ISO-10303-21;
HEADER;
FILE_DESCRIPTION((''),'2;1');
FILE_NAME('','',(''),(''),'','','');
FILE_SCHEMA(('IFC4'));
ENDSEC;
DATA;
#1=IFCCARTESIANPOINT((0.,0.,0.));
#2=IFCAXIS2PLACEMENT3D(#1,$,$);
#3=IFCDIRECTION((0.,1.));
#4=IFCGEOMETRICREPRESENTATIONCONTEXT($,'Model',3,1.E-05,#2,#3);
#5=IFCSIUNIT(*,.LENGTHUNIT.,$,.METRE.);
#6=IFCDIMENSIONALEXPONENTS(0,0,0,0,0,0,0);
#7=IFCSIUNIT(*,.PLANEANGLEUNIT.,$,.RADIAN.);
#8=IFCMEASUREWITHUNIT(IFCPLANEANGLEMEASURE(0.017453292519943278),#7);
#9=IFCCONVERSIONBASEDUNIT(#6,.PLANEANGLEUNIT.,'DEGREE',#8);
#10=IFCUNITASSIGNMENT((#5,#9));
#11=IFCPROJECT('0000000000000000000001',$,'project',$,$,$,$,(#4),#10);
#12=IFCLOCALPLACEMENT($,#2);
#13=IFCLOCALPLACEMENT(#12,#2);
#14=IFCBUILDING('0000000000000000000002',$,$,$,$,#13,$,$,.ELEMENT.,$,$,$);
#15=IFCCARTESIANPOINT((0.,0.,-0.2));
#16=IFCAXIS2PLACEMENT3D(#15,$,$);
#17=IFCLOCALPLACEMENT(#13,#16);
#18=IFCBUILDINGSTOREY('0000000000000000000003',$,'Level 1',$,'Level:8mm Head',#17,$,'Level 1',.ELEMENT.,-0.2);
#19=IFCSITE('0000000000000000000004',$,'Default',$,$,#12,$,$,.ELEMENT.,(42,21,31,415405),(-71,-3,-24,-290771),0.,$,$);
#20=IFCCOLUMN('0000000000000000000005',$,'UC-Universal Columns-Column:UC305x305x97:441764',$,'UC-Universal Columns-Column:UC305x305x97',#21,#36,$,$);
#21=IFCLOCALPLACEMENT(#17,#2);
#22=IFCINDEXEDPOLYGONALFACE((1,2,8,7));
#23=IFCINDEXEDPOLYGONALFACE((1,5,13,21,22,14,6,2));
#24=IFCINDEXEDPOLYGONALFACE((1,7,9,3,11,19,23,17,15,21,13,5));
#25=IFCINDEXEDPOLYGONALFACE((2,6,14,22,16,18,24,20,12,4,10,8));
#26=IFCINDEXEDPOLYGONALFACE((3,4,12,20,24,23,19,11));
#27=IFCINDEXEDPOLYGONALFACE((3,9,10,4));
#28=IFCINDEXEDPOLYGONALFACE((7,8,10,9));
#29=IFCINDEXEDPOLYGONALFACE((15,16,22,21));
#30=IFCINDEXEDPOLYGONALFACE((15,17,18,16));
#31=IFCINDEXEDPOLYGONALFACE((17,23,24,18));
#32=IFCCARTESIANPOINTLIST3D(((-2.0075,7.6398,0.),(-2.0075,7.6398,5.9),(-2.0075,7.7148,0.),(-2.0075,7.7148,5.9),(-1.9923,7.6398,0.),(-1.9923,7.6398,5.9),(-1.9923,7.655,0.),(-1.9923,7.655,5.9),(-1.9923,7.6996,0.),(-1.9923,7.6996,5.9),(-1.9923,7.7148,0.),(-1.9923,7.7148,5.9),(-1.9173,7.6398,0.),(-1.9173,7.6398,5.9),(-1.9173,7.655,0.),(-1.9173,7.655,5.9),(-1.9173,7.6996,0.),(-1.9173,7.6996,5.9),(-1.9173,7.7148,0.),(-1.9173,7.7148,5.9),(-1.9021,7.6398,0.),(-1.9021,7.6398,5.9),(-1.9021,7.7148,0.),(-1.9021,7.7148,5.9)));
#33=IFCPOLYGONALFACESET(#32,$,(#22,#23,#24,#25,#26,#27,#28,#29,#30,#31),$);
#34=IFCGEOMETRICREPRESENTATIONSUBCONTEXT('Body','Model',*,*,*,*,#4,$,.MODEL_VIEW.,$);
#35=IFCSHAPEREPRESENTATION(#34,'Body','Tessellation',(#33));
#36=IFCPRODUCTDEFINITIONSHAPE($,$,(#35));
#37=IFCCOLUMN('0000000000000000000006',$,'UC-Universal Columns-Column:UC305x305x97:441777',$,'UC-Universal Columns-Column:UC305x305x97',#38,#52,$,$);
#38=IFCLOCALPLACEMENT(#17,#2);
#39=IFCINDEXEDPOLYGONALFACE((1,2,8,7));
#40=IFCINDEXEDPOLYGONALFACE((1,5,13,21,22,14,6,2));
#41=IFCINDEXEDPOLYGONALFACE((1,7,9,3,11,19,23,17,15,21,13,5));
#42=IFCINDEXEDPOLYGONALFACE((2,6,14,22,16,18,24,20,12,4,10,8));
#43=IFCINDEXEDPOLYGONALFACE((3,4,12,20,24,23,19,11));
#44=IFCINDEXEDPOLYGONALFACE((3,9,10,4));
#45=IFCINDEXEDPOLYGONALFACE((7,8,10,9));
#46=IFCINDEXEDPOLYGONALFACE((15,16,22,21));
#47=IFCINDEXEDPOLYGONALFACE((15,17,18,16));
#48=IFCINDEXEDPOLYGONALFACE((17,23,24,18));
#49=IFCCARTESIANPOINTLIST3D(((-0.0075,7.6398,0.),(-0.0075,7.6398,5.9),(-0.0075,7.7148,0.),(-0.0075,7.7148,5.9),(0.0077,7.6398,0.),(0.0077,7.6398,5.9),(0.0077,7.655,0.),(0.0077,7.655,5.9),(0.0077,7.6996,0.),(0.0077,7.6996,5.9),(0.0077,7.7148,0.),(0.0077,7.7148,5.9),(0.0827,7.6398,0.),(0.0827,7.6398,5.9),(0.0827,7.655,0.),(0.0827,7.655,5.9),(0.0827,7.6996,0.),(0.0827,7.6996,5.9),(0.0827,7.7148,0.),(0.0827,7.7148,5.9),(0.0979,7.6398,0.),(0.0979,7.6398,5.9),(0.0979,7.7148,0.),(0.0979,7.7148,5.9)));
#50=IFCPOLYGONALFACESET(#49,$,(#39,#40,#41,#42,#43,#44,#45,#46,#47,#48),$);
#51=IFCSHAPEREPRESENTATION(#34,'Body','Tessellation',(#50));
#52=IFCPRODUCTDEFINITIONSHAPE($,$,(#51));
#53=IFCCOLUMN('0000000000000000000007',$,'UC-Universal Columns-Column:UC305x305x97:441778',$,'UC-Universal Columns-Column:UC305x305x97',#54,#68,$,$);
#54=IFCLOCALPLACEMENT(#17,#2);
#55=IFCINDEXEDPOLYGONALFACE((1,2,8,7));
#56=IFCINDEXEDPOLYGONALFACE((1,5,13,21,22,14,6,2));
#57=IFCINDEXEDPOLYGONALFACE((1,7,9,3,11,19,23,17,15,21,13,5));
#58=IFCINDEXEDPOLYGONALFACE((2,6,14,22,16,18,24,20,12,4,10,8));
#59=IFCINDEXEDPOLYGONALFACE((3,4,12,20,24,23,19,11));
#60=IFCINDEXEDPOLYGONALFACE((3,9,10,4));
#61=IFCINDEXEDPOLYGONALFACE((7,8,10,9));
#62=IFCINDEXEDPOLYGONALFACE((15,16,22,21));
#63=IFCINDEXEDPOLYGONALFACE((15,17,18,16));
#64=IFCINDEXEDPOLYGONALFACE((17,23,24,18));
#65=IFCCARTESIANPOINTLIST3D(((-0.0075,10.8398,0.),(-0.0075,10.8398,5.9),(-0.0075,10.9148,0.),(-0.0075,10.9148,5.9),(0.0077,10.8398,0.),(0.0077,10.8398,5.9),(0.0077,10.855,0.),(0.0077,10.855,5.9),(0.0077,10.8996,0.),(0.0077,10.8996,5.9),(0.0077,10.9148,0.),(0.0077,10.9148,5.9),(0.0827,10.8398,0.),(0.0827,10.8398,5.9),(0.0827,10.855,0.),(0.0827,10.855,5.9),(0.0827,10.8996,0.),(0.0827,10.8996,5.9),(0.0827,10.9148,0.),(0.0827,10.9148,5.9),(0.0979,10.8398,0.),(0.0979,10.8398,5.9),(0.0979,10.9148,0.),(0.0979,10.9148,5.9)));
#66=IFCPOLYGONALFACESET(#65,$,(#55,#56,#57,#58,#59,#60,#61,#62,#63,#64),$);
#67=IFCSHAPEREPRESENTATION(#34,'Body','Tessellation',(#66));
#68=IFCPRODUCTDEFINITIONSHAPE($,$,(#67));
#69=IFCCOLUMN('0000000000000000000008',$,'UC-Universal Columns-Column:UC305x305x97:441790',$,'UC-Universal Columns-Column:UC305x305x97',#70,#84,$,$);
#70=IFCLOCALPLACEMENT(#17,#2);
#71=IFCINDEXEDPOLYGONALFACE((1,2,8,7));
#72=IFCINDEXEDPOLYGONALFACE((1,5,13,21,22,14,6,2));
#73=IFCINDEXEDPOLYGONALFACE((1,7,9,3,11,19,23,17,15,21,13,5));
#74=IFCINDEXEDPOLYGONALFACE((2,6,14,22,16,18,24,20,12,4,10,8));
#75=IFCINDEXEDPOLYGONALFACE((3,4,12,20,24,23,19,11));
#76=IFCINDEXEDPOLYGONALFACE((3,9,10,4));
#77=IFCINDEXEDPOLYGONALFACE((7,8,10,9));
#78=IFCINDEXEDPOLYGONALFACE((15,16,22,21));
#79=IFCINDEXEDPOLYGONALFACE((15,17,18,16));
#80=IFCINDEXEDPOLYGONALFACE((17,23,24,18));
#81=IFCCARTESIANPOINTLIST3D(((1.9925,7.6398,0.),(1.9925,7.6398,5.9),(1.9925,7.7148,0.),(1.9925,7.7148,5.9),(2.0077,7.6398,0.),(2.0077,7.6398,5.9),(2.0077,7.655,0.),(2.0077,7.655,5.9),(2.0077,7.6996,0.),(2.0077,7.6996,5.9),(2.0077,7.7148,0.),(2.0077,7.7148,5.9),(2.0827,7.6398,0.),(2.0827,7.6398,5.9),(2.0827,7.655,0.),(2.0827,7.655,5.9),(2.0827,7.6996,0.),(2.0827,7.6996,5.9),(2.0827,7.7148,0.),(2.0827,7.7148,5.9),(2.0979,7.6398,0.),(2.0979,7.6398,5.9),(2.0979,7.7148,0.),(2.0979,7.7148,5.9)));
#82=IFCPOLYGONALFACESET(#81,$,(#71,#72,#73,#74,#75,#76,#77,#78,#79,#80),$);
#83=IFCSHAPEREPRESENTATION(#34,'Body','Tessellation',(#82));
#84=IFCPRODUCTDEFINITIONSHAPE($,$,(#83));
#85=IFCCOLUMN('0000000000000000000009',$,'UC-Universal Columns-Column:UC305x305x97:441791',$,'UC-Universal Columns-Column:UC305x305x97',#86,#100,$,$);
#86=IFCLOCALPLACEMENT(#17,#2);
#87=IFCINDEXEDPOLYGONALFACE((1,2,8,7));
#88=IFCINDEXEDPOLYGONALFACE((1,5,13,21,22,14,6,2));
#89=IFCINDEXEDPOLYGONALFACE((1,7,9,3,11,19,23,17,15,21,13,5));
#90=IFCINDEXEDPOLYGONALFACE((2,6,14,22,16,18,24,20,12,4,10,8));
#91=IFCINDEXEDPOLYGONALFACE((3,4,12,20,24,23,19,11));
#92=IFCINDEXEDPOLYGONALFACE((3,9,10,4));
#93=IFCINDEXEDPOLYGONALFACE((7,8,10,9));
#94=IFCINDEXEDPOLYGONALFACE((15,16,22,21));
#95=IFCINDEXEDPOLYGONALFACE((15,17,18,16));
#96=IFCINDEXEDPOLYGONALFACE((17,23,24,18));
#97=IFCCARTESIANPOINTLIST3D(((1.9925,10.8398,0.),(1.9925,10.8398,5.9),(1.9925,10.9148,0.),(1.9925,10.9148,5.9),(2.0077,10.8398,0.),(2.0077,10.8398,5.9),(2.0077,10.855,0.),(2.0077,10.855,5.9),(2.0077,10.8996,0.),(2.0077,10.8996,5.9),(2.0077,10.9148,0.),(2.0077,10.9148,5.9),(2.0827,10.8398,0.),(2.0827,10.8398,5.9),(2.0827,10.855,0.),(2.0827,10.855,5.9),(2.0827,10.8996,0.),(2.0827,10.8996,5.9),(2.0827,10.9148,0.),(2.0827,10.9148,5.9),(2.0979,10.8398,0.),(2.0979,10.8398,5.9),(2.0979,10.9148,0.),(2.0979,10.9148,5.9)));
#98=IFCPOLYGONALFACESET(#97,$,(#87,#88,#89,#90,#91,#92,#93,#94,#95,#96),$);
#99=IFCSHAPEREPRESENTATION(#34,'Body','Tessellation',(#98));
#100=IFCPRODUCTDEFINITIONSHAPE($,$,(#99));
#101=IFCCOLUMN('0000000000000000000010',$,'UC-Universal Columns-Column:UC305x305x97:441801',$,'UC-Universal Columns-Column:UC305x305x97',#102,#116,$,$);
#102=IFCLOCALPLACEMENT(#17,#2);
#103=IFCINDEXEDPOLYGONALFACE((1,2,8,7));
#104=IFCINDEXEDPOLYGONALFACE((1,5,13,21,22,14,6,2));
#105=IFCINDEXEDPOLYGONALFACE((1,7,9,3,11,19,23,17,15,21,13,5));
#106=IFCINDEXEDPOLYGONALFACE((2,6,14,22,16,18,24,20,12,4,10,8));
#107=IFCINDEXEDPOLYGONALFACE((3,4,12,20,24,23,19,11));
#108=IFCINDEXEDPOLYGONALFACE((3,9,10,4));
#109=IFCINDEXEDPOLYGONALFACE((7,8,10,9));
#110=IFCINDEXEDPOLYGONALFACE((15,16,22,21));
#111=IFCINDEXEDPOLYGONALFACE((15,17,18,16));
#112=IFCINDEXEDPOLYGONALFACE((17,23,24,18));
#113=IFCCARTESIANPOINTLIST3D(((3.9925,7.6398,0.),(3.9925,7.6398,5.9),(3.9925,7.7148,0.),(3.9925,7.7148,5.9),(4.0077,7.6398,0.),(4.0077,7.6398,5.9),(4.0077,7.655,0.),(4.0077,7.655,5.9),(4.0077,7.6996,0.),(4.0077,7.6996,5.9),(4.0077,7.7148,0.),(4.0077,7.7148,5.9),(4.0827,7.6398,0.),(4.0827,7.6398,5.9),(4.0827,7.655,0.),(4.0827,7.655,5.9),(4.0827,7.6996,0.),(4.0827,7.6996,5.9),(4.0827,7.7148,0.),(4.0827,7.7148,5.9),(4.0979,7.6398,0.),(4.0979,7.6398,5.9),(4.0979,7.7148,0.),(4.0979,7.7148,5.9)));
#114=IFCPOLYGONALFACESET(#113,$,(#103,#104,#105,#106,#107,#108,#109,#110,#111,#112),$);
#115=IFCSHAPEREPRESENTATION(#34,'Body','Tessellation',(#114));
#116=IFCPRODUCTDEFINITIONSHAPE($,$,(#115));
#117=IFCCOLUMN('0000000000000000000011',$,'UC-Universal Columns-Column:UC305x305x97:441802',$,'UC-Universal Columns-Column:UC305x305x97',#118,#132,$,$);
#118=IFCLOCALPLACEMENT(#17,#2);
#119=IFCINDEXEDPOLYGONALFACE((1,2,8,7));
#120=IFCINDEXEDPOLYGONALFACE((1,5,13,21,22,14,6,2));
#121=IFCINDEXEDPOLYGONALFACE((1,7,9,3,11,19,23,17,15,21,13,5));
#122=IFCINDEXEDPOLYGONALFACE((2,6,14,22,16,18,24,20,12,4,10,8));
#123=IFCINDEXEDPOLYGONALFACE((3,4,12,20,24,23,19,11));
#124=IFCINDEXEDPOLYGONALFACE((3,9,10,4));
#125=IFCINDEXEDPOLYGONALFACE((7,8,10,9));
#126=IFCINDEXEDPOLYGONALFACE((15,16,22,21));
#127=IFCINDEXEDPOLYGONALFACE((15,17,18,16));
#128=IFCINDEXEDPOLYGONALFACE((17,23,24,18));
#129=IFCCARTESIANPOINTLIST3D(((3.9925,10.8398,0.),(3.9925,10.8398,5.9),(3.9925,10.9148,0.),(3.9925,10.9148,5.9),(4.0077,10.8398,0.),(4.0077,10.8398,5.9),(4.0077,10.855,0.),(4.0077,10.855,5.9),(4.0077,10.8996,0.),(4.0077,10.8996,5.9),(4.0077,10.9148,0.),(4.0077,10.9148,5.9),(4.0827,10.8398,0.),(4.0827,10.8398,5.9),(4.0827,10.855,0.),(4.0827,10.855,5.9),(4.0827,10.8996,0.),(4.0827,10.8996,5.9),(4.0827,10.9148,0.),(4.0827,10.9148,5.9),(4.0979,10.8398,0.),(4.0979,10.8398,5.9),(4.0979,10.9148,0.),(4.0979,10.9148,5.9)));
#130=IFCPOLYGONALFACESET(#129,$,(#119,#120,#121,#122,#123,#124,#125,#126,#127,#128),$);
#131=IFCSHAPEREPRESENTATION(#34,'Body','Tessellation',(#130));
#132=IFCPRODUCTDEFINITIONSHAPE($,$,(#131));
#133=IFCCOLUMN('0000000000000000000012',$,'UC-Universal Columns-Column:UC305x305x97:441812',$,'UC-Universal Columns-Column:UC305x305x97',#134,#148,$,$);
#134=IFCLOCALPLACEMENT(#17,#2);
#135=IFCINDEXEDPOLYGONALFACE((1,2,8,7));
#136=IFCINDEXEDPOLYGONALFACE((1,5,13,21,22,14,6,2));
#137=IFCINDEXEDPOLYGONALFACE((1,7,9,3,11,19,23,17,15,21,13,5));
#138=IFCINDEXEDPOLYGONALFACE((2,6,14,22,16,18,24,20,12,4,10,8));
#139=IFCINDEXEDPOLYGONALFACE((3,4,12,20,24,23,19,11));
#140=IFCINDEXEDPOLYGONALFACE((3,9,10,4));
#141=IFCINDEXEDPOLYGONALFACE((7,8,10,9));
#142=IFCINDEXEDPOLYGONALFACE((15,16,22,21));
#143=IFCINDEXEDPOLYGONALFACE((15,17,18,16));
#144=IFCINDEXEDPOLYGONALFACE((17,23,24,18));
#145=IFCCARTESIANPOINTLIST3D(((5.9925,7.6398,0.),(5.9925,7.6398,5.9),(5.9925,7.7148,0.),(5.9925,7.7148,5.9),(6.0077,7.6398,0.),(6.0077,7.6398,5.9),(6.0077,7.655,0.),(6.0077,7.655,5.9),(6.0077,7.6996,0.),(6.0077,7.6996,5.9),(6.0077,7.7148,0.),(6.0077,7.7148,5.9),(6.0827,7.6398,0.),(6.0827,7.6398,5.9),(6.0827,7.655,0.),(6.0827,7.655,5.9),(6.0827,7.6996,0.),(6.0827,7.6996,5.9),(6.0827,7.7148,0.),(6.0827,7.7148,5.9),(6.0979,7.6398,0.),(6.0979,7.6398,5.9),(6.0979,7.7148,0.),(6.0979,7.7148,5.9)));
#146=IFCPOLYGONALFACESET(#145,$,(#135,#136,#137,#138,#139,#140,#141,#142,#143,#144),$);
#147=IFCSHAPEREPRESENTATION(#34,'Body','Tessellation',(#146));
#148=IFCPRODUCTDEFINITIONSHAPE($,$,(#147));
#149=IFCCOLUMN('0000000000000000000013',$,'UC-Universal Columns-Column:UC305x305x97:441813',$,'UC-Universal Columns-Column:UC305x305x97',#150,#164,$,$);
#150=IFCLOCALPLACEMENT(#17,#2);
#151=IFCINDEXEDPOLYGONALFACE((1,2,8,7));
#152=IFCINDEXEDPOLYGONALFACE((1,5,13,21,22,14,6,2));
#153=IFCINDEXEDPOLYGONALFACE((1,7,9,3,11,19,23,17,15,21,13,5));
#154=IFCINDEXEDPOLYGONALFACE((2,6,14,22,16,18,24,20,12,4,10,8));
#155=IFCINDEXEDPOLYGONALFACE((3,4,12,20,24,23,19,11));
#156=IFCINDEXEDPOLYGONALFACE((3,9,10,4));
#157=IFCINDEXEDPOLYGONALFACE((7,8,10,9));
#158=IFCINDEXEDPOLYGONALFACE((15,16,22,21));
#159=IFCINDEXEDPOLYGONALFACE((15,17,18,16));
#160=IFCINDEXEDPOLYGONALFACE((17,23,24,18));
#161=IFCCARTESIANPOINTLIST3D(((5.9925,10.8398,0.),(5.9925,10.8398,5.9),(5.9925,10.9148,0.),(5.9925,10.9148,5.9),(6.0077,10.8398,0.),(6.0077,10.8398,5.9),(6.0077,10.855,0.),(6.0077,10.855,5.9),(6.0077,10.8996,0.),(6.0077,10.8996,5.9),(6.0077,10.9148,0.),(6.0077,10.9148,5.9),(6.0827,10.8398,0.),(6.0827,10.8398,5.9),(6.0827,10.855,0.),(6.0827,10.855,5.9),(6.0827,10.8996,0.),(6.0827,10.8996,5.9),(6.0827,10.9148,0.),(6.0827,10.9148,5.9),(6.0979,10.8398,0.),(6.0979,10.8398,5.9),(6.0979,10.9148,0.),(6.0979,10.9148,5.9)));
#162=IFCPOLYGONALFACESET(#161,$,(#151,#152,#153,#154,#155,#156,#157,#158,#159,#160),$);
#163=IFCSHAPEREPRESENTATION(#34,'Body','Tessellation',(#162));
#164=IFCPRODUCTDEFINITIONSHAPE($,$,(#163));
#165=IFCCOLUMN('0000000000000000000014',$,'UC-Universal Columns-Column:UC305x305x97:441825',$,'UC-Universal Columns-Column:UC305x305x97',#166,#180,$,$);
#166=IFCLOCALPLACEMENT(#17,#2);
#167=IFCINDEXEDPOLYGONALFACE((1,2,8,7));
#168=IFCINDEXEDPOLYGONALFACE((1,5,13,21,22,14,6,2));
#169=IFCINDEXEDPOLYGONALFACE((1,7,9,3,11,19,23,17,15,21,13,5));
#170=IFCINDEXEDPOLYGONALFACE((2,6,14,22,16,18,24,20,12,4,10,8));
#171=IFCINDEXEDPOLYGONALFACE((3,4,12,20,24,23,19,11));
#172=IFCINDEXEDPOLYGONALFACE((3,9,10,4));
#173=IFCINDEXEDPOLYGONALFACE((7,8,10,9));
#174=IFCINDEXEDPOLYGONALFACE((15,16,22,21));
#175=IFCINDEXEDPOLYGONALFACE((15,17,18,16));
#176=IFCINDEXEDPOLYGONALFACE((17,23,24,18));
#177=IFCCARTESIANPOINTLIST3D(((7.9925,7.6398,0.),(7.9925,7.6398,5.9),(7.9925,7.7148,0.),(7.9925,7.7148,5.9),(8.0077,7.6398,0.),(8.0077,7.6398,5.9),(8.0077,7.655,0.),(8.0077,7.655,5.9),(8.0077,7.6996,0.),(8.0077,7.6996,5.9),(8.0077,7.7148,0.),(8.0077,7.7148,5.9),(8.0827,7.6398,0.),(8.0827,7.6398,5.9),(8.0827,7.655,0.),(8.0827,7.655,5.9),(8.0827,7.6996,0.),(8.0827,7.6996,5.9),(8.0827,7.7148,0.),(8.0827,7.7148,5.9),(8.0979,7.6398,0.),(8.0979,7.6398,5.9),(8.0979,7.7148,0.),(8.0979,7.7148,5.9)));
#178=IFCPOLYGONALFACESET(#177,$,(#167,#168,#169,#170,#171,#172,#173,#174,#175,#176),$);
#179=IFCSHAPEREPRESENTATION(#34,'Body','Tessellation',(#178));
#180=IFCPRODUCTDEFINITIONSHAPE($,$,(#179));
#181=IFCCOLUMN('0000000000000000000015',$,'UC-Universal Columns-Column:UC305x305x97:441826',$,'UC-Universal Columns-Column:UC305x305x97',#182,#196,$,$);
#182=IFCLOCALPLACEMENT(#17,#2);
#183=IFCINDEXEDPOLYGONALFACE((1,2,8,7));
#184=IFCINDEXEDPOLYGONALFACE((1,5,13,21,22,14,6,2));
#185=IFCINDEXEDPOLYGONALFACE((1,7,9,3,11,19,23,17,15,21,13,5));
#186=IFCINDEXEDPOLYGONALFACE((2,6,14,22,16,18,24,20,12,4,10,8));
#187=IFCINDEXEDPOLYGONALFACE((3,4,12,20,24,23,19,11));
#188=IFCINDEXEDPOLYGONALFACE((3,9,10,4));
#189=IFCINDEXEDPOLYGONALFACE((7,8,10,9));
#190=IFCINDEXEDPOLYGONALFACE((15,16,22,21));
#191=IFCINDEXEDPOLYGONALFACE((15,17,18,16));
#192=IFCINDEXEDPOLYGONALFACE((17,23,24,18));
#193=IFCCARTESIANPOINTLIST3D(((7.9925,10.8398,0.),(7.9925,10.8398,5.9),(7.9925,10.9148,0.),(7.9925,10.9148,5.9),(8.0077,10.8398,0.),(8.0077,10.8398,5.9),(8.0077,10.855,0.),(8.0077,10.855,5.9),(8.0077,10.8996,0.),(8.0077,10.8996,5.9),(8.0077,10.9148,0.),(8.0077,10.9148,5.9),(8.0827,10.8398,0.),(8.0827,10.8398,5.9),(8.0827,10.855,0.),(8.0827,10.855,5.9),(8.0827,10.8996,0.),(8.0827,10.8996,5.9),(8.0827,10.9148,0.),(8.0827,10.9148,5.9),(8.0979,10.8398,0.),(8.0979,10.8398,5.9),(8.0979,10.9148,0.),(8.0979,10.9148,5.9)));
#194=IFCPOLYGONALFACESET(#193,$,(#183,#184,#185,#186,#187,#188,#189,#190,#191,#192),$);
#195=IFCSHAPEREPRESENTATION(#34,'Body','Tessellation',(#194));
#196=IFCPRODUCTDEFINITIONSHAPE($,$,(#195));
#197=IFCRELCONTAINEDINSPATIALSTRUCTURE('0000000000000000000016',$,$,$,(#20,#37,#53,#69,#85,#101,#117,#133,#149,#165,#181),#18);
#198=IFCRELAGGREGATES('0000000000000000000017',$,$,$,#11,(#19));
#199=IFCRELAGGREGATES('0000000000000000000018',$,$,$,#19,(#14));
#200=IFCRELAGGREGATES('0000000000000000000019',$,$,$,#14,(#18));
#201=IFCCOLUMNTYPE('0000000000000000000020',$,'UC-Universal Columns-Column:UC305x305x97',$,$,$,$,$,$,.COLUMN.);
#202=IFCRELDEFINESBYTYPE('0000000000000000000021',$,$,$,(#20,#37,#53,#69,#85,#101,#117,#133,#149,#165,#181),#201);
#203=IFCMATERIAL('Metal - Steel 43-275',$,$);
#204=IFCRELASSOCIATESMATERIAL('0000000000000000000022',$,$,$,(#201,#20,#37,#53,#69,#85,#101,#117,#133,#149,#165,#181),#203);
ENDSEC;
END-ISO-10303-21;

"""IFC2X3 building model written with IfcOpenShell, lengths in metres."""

from ifc_helpers import new_model, entity, si_unit, converted_unit, direction, frame, frame_2d, origin, place, context, subcontext, project, spatial, polyline, circle_curve, parameter, trimmed, segment, composite_curve, outline, extrude, source, transform, mapped, material, type_object, type_shapes, element, save


model = new_model("IFC2X3")

# Units and contexts
model_context = context("Model", 3, precision=1e-05, world=origin(), true_north=direction((0.0, 1.0)))
body_context = subcontext(model_context, "Body", "Model", "MODEL_VIEW")
ifc_project = project(units=[si_unit("LENGTHUNIT", "METRE"), converted_unit("PLANEANGLEUNIT", "DEGREE", entity("IfcPlaneAngleMeasure", 0.017453292519943278), si_unit("PLANEANGLEUNIT", "RADIAN"), dimensions=[0, 0, 0, 0, 0, 0, 0])], contexts=[model_context])

# Site, building, storey
site_placement = place(None, origin())
site = spatial("IfcSite", under=ifc_project, at=site_placement, Name="Default", CompositionType="ELEMENT", RefLatitude=(42, 21, 31, 415405), RefLongitude=(-71, -3, -24, -290771), RefElevation=0.0)
building_placement = place(site_placement, origin())
building = spatial("IfcBuilding", under=site, at=building_placement, CompositionType="ELEMENT")
storey_placement = place(building_placement, frame((0.0, 0.0, -0.2)))
storey = spatial("IfcBuildingStorey", under=building, at=storey_placement, Name="Level 1", ObjectType="Level:8mm Head", LongName="Level 1", CompositionType="ELEMENT", Elevation=-0.2)

# Columns
ifc_material_1 = material(Name="Metal - Steel 43-275")
column_type_1 = type_object("IfcColumnType", Name="UC-Universal Columns-Column:UC305x305x97", PredefinedType="COLUMN", material=ifc_material_1)
shared_shape_1 = source(origin(), body_context, "Body", "SweptSolid", [
    extrude(outline(composite_curve([segment(polyline([(-0.0375, -0.0375), (0.0375, -0.0375)]), True, "CONTINUOUS"), segment(polyline([(0.0375, -0.0375), (0.0527, -0.0375)]), True, "CONTINUOUS"), segment(trimmed(circle_curve(frame_2d((0.0527, -0.0223), x_axis=(-1.0, 0.0)), 0.0152), [parameter(0.0)], [parameter(90.0)], True, "PARAMETER"), False, "CONTINUOUS"), segment(polyline([(0.0375, -0.0223), (0.0375, 0.0223)]), True, "CONTINUOUS"), segment(trimmed(circle_curve(frame_2d((0.0527, 0.0223), x_axis=(-1.0, 0.0)), 0.0152), [parameter(270.0)], [parameter(0.0)], True, "PARAMETER"), False, "CONTINUOUS"), segment(polyline([(0.0527, 0.0375), (0.0375, 0.0375)]), True, "CONTINUOUS"), segment(polyline([(0.0375, 0.0375), (-0.0375, 0.0375)]), True, "CONTINUOUS"), segment(polyline([(-0.0375, 0.0375), (-0.0527, 0.0375)]), True, "CONTINUOUS"), segment(trimmed(circle_curve(frame_2d((-0.0527, 0.0223), x_axis=(-1.0, 0.0)), 0.0152), [parameter(180.0)], [parameter(270.0)], True, "PARAMETER"), False, "CONTINUOUS"), segment(polyline([(-0.0375, 0.0223), (-0.0375, -0.0223)]), True, "CONTINUOUS"), segment(trimmed(circle_curve(frame_2d((-0.0527, -0.0223), x_axis=(-1.0, 0.0)), 0.0152), [parameter(90.0)], [parameter(180.0)], True, "PARAMETER"), False, "CONTINUOUS"), segment(polyline([(-0.0527, -0.0375), (-0.0375, -0.0375)]), True, "CONTINUOUS")], self_intersect=False)), frame((0.0, 0.0, -0.2), z_axis=(0.0, 0.0, 1.0), x_axis=(-1.0, 0.0, 0.0)), (0.0, 0.0, 1.0), 5.9),
])
type_shapes(column_type_1, [shared_shape_1])
for number, where, z_axis, x_axis, name in (
    (1, (-1.9548, 7.6773, 0.2), (0.0, 0.0, 1.0), (-1.0, 0.0, 0.0), "UC-Universal Columns-Column:UC305x305x97:441764"),
    (2, (0.0452, 7.6773, 0.2), (0.0, 0.0, 1.0), (-1.0, 0.0, 0.0), "UC-Universal Columns-Column:UC305x305x97:441777"),
    (3, (0.0452, 10.8773, 0.2), (0.0, 0.0, 1.0), (-1.0, 0.0, 0.0), "UC-Universal Columns-Column:UC305x305x97:441778"),
    (4, (2.0452, 7.6773, 0.2), (0.0, 0.0, 1.0), (-1.0, 0.0, 0.0), "UC-Universal Columns-Column:UC305x305x97:441790"),
    (5, (2.0452, 10.8773, 0.2), (0.0, 0.0, 1.0), (-1.0, 0.0, 0.0), "UC-Universal Columns-Column:UC305x305x97:441791"),
    (6, (4.0452, 7.6773, 0.2), (0.0, 0.0, 1.0), (-1.0, 0.0, 0.0), "UC-Universal Columns-Column:UC305x305x97:441801"),
    (7, (4.0452, 10.8773, 0.2), (0.0, 0.0, 1.0), (-1.0, 0.0, 0.0), "UC-Universal Columns-Column:UC305x305x97:441802"),
    (8, (6.0452, 7.6773, 0.2), (0.0, 0.0, 1.0), (-1.0, 0.0, 0.0), "UC-Universal Columns-Column:UC305x305x97:441812"),
    (9, (6.0452, 10.8773, 0.2), (0.0, 0.0, 1.0), (-1.0, 0.0, 0.0), "UC-Universal Columns-Column:UC305x305x97:441813"),
    (10, (8.0452, 7.6773, 0.2), (0.0, 0.0, 1.0), (-1.0, 0.0, 0.0), "UC-Universal Columns-Column:UC305x305x97:441825"),
    (11, (8.0452, 10.8773, 0.2), (0.0, 0.0, 1.0), (-1.0, 0.0, 0.0), "UC-Universal Columns-Column:UC305x305x97:441826"),
):
    element("IfcColumn", number, at=place(storey_placement, frame(where, z_axis=z_axis, x_axis=x_axis)), inside=storey, type_object=column_type_1, material=ifc_material_1, Name=name, ObjectType="UC-Universal Columns-Column:UC305x305x97", context=body_context, shape_type="MappedRepresentation", body=[
        mapped(shared_shape_1, transform((0.0, 0.0, 0.0), scale=1.0)),
    ])

save(model, "model.ifc")
